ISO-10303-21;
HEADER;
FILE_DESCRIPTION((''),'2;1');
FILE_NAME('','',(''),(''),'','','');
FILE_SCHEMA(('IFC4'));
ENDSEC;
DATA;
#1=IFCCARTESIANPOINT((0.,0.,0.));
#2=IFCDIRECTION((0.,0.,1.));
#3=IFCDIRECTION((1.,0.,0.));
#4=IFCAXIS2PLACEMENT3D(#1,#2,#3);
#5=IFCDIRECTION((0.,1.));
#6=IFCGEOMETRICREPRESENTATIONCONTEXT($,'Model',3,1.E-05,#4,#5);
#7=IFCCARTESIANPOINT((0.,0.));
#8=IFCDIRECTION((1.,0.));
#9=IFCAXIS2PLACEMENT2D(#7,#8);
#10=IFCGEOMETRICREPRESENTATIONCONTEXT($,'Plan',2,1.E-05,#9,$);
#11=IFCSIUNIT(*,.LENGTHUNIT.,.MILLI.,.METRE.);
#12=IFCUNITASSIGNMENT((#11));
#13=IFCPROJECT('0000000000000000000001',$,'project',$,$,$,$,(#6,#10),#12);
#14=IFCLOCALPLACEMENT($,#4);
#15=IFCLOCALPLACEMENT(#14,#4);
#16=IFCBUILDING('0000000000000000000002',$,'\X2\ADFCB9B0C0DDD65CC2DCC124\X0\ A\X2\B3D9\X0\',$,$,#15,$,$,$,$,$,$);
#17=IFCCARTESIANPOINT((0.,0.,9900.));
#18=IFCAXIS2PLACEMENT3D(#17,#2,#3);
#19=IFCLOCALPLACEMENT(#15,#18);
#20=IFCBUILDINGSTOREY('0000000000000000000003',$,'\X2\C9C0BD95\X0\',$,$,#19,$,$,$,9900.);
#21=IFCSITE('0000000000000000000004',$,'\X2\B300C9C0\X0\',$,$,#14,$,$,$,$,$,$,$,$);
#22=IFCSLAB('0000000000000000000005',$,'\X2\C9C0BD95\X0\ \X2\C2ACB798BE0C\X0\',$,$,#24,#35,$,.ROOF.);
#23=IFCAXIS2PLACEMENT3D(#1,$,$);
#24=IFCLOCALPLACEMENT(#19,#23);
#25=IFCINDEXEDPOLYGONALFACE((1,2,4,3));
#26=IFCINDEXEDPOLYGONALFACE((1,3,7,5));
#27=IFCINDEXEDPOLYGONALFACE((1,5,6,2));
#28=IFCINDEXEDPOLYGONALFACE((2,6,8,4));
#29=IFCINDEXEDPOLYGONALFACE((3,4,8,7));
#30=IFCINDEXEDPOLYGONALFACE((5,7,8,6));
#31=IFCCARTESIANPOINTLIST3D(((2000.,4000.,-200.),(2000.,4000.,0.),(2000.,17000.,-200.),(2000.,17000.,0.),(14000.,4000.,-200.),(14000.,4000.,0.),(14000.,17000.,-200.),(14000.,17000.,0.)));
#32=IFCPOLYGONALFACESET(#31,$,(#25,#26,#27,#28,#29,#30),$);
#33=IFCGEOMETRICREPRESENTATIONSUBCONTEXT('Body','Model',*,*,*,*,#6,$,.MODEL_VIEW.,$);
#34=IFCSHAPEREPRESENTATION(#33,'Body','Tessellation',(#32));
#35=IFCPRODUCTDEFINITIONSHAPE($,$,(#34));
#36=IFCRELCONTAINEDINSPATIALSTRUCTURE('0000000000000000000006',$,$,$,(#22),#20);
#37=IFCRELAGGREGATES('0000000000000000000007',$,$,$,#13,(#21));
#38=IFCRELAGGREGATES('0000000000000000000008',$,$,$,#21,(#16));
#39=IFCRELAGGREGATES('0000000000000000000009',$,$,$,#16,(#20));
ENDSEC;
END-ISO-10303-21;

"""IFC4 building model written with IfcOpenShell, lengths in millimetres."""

from ifc_helpers import new_model, si_unit, direction, frame, origin_with_axes, origin_2d_with_axis, place, context, subcontext, project, spatial, polyline, outline, extrude, element, save


model = new_model("IFC4")

# Units and contexts
model_context = context("Model", 3, precision=1e-05, world=origin_with_axes(), true_north=direction((0.0, 1.0)))
plan_context = context("Plan", 2, precision=1e-05, world=origin_2d_with_axis())
body_context = subcontext(model_context, "Body", "Model", "MODEL_VIEW")
ifc_project = project(units=[si_unit("LENGTHUNIT", "METRE", prefix="MILLI")], contexts=[model_context, plan_context])

# Site, building, storey
site_placement = place(None, origin_with_axes())
site = spatial("IfcSite", under=ifc_project, at=site_placement, Name="대지")
building_placement = place(site_placement, origin_with_axes())
building = spatial("IfcBuilding", under=site, at=building_placement, Name="근린생활시설 A동")
storey_placement = place(building_placement, frame((0.0, 0.0, 9900.0), z_axis=(0.0, 0.0, 1.0), x_axis=(1.0, 0.0, 0.0)))
storey = spatial("IfcBuildingStorey", under=building, at=storey_placement, Name="지붕", Elevation=9900.0)

# Slab
slab_placement = place(storey_placement, origin_with_axes())
element("IfcSlab", 1, at=slab_placement, inside=storey, Name="지붕 슬래브", PredefinedType="ROOF", context=body_context, shape_type="SweptSolid", body=[
    extrude(outline(polyline([(2000.0, 4000.0), (14000.0, 4000.0), (14000.0, 17000.0), (2000.0, 17000.0), (2000.0, 4000.0)])), frame((0.0, 0.0, -200.0), z_axis=(0.0, 0.0, 1.0), x_axis=(1.0, 0.0, 0.0)), (0.0, 0.0, 1.0), 200.0),
])

save(model, "model.ifc")
